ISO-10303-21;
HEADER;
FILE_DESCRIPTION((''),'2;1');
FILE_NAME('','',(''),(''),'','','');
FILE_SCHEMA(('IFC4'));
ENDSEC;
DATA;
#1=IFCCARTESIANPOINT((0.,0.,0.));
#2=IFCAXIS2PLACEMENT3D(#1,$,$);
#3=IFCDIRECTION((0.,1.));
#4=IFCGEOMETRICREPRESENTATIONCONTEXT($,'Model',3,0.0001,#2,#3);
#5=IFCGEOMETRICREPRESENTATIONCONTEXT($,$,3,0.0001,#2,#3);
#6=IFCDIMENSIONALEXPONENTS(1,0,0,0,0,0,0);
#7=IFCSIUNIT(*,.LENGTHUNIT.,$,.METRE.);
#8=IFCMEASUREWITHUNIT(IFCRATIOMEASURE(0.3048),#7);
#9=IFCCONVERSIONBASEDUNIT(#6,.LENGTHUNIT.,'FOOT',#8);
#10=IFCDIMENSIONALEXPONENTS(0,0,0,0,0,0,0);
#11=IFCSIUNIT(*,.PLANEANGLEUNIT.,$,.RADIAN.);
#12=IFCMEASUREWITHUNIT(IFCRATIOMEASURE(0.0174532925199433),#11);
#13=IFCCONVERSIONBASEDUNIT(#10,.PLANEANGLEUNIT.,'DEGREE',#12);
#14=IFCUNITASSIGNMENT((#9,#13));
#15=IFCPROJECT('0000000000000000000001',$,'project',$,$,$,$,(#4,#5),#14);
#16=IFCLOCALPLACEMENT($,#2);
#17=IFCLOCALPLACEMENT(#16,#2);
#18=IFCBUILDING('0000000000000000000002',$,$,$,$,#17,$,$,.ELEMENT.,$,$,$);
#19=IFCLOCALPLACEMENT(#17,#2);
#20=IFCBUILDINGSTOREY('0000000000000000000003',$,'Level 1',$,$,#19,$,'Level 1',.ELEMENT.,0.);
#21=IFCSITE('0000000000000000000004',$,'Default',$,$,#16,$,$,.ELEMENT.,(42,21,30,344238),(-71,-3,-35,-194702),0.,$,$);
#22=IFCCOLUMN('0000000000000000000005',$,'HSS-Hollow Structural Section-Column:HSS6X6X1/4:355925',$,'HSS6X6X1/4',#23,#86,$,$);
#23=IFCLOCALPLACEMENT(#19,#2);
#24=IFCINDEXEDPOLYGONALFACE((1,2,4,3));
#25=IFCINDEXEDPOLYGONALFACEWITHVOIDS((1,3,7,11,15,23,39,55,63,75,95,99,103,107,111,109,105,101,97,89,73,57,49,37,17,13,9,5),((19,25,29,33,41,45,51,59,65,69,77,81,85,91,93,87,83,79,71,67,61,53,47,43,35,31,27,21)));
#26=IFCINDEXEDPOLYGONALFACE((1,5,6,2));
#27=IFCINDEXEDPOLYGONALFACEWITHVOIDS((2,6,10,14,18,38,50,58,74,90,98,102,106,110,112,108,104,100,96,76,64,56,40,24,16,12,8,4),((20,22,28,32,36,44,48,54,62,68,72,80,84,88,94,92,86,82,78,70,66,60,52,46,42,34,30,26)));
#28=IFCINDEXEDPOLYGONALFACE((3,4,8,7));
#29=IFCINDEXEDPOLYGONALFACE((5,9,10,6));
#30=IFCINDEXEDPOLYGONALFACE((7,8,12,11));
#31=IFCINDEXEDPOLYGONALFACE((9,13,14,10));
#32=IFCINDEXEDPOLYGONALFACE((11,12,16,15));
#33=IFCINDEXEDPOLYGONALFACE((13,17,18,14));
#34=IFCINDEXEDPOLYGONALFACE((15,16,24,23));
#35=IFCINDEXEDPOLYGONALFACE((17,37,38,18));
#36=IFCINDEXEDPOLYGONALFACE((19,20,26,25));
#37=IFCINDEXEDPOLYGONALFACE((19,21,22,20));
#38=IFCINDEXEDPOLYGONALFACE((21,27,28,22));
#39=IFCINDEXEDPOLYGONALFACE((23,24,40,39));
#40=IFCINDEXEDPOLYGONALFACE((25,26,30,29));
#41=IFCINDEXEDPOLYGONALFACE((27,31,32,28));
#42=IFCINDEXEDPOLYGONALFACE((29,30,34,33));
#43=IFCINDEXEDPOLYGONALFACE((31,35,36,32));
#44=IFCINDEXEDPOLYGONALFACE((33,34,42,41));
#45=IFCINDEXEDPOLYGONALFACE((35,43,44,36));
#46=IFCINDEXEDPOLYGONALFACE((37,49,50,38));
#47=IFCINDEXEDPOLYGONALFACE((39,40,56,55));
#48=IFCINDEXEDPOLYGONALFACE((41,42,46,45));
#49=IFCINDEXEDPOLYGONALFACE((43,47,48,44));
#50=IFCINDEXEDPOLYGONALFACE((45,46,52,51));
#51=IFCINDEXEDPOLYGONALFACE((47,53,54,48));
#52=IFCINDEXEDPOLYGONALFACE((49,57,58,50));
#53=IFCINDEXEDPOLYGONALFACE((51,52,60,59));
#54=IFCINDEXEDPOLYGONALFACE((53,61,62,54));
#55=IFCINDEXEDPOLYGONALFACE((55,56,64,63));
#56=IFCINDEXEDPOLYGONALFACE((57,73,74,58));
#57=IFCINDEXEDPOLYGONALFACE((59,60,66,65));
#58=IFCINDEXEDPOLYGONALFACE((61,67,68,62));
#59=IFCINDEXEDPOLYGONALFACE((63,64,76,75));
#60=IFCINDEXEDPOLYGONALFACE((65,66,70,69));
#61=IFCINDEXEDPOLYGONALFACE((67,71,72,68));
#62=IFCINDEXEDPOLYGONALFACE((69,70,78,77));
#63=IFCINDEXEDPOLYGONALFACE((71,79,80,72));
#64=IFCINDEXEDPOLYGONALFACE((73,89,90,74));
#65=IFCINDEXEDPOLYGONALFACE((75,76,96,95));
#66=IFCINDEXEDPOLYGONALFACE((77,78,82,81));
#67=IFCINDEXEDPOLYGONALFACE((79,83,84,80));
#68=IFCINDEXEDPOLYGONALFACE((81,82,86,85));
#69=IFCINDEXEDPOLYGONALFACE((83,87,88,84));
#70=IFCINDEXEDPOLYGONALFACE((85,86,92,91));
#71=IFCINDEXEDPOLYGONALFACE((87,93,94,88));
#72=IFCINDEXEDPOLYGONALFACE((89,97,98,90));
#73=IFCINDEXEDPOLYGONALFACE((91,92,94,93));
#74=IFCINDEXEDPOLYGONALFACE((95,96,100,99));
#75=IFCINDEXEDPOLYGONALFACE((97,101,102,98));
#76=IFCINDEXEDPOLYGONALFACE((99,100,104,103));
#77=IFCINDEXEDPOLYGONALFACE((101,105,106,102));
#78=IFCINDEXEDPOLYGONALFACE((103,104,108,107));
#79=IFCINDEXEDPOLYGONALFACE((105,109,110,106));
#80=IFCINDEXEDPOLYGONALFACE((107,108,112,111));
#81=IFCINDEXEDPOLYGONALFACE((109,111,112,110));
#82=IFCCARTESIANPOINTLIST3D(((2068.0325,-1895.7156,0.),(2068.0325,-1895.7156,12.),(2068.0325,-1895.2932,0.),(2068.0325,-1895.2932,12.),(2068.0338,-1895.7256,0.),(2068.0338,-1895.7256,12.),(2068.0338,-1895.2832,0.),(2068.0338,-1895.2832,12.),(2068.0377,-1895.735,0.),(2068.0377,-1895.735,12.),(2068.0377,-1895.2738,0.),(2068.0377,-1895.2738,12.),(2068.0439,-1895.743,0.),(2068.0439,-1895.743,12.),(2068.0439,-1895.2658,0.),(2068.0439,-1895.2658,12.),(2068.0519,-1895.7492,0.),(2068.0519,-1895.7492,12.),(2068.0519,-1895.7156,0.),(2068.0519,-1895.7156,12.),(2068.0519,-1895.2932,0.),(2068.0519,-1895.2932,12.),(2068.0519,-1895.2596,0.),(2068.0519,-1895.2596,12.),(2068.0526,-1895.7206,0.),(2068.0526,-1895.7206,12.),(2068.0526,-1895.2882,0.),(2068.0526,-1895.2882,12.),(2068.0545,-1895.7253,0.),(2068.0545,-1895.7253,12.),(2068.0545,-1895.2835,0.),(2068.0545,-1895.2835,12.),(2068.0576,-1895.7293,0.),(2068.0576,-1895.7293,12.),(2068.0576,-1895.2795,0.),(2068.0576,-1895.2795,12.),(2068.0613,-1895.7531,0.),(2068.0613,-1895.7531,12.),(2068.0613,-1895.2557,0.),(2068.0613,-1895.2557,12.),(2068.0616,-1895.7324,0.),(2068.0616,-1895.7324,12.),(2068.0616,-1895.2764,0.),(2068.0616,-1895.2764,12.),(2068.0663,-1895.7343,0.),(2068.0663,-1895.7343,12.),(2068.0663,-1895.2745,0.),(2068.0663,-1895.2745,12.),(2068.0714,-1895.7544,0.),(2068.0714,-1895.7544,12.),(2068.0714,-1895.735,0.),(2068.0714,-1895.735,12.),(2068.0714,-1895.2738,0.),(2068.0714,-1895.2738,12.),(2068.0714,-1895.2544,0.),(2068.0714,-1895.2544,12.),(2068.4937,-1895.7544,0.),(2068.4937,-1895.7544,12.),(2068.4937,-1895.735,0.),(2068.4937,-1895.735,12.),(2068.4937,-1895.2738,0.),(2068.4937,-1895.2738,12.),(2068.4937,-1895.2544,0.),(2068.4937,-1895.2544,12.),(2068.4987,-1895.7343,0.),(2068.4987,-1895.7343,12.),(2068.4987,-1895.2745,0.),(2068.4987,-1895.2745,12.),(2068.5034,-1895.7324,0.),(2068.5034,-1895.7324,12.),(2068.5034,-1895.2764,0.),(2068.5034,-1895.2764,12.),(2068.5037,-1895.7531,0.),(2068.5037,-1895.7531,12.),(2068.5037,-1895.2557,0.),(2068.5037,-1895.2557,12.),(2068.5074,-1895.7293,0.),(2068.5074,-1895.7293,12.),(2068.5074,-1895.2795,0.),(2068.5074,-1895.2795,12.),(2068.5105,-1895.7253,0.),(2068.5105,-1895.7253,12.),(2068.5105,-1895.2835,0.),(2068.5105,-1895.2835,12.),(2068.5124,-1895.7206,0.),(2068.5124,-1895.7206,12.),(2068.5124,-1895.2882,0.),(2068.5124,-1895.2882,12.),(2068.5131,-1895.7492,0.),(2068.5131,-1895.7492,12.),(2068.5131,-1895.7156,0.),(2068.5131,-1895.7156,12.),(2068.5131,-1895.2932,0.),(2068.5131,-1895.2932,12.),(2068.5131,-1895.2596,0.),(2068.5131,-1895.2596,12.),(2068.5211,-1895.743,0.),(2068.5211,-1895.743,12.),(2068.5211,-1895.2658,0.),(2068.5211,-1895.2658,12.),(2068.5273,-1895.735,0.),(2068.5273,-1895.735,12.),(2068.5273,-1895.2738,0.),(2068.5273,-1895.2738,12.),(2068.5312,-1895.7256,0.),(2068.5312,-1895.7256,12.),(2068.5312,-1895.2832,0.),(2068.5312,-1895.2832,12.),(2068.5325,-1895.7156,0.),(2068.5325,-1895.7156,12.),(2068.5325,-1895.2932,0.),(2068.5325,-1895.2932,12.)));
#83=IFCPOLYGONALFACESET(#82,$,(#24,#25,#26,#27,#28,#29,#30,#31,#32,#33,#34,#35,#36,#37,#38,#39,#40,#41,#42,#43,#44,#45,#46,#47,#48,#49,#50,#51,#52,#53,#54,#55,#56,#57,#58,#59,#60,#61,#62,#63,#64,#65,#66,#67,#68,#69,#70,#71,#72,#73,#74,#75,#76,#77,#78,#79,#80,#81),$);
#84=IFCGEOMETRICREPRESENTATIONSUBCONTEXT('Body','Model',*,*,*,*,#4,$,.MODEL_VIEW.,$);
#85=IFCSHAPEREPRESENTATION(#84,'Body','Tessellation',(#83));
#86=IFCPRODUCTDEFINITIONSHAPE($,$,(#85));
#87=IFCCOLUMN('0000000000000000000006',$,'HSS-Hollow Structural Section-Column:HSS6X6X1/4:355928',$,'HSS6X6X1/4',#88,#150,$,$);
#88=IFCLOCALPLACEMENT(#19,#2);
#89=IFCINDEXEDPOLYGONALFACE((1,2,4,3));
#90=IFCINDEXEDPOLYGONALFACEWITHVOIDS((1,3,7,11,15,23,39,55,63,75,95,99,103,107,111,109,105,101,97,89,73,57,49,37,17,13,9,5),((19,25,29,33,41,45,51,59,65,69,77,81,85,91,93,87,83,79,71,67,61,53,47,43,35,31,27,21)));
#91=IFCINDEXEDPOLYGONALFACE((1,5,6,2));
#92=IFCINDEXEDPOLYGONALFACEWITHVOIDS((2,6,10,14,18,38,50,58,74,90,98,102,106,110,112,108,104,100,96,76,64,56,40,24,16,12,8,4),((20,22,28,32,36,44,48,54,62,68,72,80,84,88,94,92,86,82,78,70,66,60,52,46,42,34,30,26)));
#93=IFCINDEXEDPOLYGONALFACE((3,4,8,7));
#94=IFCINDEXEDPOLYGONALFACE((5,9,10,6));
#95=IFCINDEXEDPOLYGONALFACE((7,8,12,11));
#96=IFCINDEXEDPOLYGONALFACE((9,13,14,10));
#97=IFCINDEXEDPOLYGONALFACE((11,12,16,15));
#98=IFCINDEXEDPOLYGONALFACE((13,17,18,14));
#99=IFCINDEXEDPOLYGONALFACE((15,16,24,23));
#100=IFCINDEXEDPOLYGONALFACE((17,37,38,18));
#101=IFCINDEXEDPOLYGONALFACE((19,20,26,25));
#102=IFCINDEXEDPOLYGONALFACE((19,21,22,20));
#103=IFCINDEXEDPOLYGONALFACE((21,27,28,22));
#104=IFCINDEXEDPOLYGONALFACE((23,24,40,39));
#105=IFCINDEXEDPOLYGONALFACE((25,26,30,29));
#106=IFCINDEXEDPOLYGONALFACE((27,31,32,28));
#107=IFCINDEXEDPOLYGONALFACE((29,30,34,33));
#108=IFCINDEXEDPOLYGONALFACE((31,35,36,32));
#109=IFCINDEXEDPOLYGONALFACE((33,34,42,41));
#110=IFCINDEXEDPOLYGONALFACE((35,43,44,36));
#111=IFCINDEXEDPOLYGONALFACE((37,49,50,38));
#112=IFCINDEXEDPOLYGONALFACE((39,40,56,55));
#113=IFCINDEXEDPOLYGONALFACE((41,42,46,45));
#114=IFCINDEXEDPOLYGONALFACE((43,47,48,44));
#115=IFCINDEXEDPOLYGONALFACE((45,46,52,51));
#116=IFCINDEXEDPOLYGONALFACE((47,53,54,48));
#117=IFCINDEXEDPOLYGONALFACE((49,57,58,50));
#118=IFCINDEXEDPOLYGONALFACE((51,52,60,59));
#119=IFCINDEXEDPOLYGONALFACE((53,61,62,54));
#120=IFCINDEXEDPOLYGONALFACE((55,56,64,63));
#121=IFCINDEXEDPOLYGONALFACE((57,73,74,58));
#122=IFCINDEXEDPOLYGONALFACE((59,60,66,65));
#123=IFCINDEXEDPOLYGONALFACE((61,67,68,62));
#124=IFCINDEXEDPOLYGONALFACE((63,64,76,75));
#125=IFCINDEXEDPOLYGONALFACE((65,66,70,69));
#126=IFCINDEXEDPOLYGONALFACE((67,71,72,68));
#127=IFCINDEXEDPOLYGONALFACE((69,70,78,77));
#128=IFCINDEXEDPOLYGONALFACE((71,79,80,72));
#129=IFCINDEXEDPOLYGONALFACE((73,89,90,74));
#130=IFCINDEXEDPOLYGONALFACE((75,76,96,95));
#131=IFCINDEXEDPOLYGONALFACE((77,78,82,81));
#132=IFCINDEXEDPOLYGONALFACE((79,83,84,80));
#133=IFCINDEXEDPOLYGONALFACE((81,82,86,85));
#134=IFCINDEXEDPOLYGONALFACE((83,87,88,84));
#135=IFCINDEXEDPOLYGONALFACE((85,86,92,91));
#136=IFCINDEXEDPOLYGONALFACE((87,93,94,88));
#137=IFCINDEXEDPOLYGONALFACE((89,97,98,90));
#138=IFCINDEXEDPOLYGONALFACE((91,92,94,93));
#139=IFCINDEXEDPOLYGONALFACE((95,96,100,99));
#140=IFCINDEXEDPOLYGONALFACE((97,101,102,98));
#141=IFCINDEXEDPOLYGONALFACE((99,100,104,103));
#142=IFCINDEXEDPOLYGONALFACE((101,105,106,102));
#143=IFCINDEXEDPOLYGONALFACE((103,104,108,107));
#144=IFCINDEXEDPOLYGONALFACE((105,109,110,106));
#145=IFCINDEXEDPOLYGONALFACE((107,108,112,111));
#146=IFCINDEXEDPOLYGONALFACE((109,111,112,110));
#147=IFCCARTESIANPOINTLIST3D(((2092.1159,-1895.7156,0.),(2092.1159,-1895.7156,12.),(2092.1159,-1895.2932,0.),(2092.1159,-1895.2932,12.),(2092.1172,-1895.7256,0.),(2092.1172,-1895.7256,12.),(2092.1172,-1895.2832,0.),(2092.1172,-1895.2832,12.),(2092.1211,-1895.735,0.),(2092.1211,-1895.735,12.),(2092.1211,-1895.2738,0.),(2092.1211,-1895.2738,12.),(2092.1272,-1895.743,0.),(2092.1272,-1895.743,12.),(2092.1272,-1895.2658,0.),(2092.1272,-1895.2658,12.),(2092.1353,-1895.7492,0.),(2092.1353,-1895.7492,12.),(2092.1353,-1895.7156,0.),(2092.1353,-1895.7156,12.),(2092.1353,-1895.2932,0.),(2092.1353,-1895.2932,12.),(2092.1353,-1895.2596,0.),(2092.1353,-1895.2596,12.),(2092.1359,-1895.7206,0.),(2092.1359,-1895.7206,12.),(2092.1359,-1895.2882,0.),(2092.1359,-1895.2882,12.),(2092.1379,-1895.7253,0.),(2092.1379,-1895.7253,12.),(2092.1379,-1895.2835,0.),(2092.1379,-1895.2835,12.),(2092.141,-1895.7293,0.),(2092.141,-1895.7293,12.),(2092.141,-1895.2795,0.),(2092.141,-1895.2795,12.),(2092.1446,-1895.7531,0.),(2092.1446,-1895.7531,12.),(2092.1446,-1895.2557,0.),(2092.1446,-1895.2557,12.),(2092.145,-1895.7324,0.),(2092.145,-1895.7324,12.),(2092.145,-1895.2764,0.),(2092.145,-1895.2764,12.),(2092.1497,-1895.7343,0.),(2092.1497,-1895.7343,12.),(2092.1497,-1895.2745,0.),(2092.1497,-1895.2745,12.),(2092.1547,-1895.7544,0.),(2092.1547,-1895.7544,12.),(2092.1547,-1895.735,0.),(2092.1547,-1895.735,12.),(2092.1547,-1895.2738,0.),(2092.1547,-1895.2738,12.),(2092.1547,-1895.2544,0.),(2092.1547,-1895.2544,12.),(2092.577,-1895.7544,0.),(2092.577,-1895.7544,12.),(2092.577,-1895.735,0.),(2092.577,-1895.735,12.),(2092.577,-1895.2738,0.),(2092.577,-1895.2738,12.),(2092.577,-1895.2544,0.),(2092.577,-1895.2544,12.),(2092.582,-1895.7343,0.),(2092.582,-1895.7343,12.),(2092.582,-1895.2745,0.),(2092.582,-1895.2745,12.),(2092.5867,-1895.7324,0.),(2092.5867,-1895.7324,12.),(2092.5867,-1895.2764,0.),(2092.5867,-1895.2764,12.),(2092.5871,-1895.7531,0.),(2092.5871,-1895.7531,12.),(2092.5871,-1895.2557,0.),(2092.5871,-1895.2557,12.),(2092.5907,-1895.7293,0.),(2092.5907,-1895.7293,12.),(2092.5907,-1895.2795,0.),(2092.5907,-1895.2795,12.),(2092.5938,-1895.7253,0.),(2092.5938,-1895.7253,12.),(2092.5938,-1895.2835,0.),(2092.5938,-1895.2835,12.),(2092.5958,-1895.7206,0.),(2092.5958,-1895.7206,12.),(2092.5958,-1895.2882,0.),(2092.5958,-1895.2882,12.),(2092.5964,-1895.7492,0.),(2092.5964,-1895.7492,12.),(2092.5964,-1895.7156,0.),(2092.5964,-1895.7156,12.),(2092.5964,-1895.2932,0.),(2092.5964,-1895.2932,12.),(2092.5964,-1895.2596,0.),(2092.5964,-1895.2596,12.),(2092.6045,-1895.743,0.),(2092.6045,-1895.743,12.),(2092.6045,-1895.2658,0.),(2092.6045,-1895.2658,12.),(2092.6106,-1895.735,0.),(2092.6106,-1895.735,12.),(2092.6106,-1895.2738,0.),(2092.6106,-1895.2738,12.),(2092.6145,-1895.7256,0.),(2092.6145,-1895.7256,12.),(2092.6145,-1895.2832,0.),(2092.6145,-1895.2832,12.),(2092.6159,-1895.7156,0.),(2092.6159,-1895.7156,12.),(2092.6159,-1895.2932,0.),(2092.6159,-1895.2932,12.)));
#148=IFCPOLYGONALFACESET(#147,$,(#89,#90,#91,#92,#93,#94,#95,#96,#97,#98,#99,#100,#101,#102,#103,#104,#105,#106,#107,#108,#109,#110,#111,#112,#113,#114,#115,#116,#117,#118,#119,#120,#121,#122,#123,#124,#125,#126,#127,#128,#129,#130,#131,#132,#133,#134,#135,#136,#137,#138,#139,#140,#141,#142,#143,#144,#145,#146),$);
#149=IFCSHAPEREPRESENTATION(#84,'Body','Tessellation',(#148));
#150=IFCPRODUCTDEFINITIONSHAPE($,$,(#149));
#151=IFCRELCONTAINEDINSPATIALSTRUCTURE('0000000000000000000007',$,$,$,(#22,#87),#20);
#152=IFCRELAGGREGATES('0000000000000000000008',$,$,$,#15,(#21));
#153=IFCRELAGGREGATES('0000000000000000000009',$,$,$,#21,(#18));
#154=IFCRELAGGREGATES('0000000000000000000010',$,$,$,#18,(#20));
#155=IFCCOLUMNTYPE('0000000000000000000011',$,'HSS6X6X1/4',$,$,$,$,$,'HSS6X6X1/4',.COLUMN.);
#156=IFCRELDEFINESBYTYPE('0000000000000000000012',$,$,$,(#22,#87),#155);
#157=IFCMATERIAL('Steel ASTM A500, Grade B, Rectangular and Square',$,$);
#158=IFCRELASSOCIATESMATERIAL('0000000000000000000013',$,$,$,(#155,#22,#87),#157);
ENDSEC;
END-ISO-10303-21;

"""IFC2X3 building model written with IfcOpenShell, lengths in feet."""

from ifc_helpers import new_model, entity, si_unit, converted_unit, direction, frame, frame_2d, origin, place, context, subcontext, project, spatial, polyline, circle_curve, parameter, trimmed, segment, composite_curve, outline, extrude, source, transform, mapped, material, type_object, type_shapes, element, save


model = new_model("IFC2X3")

# Units and contexts
model_context = context("Model", 3, precision=0.0001, world=origin(), true_north=direction((0.0, 1.0)))
context_of_model = context(None, 3, precision=0.0001, world=origin(), true_north=direction((0.0, 1.0)))
body_context = subcontext(model_context, "Body", "Model", "MODEL_VIEW")
ifc_project = project(units=[converted_unit("LENGTHUNIT", "FOOT", entity("IfcRatioMeasure", 0.3048), si_unit("LENGTHUNIT", "METRE"), dimensions=[1, 0, 0, 0, 0, 0, 0]), converted_unit("PLANEANGLEUNIT", "DEGREE", entity("IfcRatioMeasure", 0.0174532925199433), si_unit("PLANEANGLEUNIT", "RADIAN"), dimensions=[0, 0, 0, 0, 0, 0, 0])], contexts=[model_context, context_of_model])

# Site, building, storey
site_placement = place(None, origin())
site = spatial("IfcSite", under=ifc_project, at=site_placement, Name="Default", CompositionType="ELEMENT", RefLatitude=(42, 21, 30, 344238), RefLongitude=(-71, -3, -35, -194702), RefElevation=0.0)
building_placement = place(site_placement, origin())
building = spatial("IfcBuilding", under=site, at=building_placement, CompositionType="ELEMENT")
storey_placement = place(building_placement, origin())
storey = spatial("IfcBuildingStorey", under=building, at=storey_placement, Name="Level 1", LongName="Level 1", CompositionType="ELEMENT", Elevation=0.0)

# Columns
ifc_material_1 = material(Name="Steel ASTM A500, Grade B, Rectangular and Square")
column_type = type_object("IfcColumnType", Name="HSS6X6X1/4", ElementType="HSS6X6X1/4", PredefinedType="COLUMN", material=ifc_material_1)
shared_shape = source(origin(), body_context, "Body", "SweptSolid", [
    extrude(outline(composite_curve([segment(polyline([(-0.2112, -0.25), (0.2112, -0.25)]), True, "CONTINUOUS"), segment(trimmed(circle_curve(frame_2d((0.2112, -0.2112), x_axis=(-1.0, 0.0)), 0.0388), [parameter(90.0)], [parameter(180.0)], True, "PARAMETER"), True, "CONTINUOUS"), segment(polyline([(0.25, -0.2112), (0.25, 0.2112)]), True, "CONTINUOUS"), segment(trimmed(circle_curve(frame_2d((0.2112, 0.2112), x_axis=(-1.0, 0.0)), 0.0388), [parameter(180.0)], [parameter(270.0)], True, "PARAMETER"), True, "CONTINUOUS"), segment(polyline([(0.2112, 0.25), (-0.2112, 0.25)]), True, "CONTINUOUS"), segment(trimmed(circle_curve(frame_2d((-0.2112, 0.2112), x_axis=(-1.0, 0.0)), 0.0388), [parameter(270.0)], [parameter(360.0)], True, "PARAMETER"), True, "CONTINUOUS"), segment(polyline([(-0.25, 0.2112), (-0.25, -0.2112)]), True, "CONTINUOUS"), segment(trimmed(circle_curve(frame_2d((-0.2112, -0.2112), x_axis=(-1.0, 0.0)), 0.0388), [parameter(360.0)], [parameter(90.0)], True, "PARAMETER"), True, "CONTINUOUS")], self_intersect=False), holes=[composite_curve([segment(trimmed(circle_curve(frame_2d((-0.2112, -0.2112), x_axis=(-1.0, 0.0)), 0.0194), [parameter(0.0)], [parameter(90.0)], True, "PARAMETER"), False, "CONTINUOUS"), segment(polyline([(-0.2306, -0.2112), (-0.2306, 0.2112)]), True, "CONTINUOUS"), segment(trimmed(circle_curve(frame_2d((-0.2112, 0.2112), x_axis=(-1.0, 0.0)), 0.0194), [parameter(270.0)], [parameter(360.0)], True, "PARAMETER"), False, "CONTINUOUS"), segment(polyline([(-0.2112, 0.2306), (0.2112, 0.2306)]), True, "CONTINUOUS"), segment(trimmed(circle_curve(frame_2d((0.2112, 0.2112), x_axis=(-1.0, 0.0)), 0.0194), [parameter(180.0)], [parameter(270.0)], True, "PARAMETER"), False, "CONTINUOUS"), segment(polyline([(0.2306, 0.2112), (0.2306, -0.2112)]), True, "CONTINUOUS"), segment(trimmed(circle_curve(frame_2d((0.2112, -0.2112), x_axis=(-1.0, 0.0)), 0.0194), [parameter(90.0)], [parameter(180.0)], True, "PARAMETER"), False, "CONTINUOUS"), segment(polyline([(0.2112, -0.2306), (-0.2112, -0.2306)]), True, "CONTINUOUS")], self_intersect=False)]), frame((0.0, 0.0, 0.0), z_axis=(0.0, 0.0, 1.0), x_axis=(-1.0, 0.0, 0.0)), (0.0, 0.0, 1.0), 12.0),
])
type_shapes(column_type, [shared_shape])
for number, where, z_axis, x_axis, name in (
    (1, (2068.2825, -1895.5044, 0.0), (0.0, 0.0, 1.0), (-1.0, 0.0, 0.0), "HSS-Hollow Structural Section-Column:HSS6X6X1/4:355925"),
    (2, (2092.3659, -1895.5044, 0.0), (0.0, 0.0, 1.0), (-1.0, 0.0, 0.0), "HSS-Hollow Structural Section-Column:HSS6X6X1/4:355928"),
):
    element("IfcColumn", number, at=place(storey_placement, frame(where, z_axis=z_axis, x_axis=x_axis)), inside=storey, type_object=column_type, material=ifc_material_1, Name=name, ObjectType="HSS6X6X1/4", context=body_context, shape_type="MappedRepresentation", body=[
        mapped(shared_shape, transform((0.0, 0.0, 0.0), scale=1.0)),
    ])

save(model, "model.ifc")
